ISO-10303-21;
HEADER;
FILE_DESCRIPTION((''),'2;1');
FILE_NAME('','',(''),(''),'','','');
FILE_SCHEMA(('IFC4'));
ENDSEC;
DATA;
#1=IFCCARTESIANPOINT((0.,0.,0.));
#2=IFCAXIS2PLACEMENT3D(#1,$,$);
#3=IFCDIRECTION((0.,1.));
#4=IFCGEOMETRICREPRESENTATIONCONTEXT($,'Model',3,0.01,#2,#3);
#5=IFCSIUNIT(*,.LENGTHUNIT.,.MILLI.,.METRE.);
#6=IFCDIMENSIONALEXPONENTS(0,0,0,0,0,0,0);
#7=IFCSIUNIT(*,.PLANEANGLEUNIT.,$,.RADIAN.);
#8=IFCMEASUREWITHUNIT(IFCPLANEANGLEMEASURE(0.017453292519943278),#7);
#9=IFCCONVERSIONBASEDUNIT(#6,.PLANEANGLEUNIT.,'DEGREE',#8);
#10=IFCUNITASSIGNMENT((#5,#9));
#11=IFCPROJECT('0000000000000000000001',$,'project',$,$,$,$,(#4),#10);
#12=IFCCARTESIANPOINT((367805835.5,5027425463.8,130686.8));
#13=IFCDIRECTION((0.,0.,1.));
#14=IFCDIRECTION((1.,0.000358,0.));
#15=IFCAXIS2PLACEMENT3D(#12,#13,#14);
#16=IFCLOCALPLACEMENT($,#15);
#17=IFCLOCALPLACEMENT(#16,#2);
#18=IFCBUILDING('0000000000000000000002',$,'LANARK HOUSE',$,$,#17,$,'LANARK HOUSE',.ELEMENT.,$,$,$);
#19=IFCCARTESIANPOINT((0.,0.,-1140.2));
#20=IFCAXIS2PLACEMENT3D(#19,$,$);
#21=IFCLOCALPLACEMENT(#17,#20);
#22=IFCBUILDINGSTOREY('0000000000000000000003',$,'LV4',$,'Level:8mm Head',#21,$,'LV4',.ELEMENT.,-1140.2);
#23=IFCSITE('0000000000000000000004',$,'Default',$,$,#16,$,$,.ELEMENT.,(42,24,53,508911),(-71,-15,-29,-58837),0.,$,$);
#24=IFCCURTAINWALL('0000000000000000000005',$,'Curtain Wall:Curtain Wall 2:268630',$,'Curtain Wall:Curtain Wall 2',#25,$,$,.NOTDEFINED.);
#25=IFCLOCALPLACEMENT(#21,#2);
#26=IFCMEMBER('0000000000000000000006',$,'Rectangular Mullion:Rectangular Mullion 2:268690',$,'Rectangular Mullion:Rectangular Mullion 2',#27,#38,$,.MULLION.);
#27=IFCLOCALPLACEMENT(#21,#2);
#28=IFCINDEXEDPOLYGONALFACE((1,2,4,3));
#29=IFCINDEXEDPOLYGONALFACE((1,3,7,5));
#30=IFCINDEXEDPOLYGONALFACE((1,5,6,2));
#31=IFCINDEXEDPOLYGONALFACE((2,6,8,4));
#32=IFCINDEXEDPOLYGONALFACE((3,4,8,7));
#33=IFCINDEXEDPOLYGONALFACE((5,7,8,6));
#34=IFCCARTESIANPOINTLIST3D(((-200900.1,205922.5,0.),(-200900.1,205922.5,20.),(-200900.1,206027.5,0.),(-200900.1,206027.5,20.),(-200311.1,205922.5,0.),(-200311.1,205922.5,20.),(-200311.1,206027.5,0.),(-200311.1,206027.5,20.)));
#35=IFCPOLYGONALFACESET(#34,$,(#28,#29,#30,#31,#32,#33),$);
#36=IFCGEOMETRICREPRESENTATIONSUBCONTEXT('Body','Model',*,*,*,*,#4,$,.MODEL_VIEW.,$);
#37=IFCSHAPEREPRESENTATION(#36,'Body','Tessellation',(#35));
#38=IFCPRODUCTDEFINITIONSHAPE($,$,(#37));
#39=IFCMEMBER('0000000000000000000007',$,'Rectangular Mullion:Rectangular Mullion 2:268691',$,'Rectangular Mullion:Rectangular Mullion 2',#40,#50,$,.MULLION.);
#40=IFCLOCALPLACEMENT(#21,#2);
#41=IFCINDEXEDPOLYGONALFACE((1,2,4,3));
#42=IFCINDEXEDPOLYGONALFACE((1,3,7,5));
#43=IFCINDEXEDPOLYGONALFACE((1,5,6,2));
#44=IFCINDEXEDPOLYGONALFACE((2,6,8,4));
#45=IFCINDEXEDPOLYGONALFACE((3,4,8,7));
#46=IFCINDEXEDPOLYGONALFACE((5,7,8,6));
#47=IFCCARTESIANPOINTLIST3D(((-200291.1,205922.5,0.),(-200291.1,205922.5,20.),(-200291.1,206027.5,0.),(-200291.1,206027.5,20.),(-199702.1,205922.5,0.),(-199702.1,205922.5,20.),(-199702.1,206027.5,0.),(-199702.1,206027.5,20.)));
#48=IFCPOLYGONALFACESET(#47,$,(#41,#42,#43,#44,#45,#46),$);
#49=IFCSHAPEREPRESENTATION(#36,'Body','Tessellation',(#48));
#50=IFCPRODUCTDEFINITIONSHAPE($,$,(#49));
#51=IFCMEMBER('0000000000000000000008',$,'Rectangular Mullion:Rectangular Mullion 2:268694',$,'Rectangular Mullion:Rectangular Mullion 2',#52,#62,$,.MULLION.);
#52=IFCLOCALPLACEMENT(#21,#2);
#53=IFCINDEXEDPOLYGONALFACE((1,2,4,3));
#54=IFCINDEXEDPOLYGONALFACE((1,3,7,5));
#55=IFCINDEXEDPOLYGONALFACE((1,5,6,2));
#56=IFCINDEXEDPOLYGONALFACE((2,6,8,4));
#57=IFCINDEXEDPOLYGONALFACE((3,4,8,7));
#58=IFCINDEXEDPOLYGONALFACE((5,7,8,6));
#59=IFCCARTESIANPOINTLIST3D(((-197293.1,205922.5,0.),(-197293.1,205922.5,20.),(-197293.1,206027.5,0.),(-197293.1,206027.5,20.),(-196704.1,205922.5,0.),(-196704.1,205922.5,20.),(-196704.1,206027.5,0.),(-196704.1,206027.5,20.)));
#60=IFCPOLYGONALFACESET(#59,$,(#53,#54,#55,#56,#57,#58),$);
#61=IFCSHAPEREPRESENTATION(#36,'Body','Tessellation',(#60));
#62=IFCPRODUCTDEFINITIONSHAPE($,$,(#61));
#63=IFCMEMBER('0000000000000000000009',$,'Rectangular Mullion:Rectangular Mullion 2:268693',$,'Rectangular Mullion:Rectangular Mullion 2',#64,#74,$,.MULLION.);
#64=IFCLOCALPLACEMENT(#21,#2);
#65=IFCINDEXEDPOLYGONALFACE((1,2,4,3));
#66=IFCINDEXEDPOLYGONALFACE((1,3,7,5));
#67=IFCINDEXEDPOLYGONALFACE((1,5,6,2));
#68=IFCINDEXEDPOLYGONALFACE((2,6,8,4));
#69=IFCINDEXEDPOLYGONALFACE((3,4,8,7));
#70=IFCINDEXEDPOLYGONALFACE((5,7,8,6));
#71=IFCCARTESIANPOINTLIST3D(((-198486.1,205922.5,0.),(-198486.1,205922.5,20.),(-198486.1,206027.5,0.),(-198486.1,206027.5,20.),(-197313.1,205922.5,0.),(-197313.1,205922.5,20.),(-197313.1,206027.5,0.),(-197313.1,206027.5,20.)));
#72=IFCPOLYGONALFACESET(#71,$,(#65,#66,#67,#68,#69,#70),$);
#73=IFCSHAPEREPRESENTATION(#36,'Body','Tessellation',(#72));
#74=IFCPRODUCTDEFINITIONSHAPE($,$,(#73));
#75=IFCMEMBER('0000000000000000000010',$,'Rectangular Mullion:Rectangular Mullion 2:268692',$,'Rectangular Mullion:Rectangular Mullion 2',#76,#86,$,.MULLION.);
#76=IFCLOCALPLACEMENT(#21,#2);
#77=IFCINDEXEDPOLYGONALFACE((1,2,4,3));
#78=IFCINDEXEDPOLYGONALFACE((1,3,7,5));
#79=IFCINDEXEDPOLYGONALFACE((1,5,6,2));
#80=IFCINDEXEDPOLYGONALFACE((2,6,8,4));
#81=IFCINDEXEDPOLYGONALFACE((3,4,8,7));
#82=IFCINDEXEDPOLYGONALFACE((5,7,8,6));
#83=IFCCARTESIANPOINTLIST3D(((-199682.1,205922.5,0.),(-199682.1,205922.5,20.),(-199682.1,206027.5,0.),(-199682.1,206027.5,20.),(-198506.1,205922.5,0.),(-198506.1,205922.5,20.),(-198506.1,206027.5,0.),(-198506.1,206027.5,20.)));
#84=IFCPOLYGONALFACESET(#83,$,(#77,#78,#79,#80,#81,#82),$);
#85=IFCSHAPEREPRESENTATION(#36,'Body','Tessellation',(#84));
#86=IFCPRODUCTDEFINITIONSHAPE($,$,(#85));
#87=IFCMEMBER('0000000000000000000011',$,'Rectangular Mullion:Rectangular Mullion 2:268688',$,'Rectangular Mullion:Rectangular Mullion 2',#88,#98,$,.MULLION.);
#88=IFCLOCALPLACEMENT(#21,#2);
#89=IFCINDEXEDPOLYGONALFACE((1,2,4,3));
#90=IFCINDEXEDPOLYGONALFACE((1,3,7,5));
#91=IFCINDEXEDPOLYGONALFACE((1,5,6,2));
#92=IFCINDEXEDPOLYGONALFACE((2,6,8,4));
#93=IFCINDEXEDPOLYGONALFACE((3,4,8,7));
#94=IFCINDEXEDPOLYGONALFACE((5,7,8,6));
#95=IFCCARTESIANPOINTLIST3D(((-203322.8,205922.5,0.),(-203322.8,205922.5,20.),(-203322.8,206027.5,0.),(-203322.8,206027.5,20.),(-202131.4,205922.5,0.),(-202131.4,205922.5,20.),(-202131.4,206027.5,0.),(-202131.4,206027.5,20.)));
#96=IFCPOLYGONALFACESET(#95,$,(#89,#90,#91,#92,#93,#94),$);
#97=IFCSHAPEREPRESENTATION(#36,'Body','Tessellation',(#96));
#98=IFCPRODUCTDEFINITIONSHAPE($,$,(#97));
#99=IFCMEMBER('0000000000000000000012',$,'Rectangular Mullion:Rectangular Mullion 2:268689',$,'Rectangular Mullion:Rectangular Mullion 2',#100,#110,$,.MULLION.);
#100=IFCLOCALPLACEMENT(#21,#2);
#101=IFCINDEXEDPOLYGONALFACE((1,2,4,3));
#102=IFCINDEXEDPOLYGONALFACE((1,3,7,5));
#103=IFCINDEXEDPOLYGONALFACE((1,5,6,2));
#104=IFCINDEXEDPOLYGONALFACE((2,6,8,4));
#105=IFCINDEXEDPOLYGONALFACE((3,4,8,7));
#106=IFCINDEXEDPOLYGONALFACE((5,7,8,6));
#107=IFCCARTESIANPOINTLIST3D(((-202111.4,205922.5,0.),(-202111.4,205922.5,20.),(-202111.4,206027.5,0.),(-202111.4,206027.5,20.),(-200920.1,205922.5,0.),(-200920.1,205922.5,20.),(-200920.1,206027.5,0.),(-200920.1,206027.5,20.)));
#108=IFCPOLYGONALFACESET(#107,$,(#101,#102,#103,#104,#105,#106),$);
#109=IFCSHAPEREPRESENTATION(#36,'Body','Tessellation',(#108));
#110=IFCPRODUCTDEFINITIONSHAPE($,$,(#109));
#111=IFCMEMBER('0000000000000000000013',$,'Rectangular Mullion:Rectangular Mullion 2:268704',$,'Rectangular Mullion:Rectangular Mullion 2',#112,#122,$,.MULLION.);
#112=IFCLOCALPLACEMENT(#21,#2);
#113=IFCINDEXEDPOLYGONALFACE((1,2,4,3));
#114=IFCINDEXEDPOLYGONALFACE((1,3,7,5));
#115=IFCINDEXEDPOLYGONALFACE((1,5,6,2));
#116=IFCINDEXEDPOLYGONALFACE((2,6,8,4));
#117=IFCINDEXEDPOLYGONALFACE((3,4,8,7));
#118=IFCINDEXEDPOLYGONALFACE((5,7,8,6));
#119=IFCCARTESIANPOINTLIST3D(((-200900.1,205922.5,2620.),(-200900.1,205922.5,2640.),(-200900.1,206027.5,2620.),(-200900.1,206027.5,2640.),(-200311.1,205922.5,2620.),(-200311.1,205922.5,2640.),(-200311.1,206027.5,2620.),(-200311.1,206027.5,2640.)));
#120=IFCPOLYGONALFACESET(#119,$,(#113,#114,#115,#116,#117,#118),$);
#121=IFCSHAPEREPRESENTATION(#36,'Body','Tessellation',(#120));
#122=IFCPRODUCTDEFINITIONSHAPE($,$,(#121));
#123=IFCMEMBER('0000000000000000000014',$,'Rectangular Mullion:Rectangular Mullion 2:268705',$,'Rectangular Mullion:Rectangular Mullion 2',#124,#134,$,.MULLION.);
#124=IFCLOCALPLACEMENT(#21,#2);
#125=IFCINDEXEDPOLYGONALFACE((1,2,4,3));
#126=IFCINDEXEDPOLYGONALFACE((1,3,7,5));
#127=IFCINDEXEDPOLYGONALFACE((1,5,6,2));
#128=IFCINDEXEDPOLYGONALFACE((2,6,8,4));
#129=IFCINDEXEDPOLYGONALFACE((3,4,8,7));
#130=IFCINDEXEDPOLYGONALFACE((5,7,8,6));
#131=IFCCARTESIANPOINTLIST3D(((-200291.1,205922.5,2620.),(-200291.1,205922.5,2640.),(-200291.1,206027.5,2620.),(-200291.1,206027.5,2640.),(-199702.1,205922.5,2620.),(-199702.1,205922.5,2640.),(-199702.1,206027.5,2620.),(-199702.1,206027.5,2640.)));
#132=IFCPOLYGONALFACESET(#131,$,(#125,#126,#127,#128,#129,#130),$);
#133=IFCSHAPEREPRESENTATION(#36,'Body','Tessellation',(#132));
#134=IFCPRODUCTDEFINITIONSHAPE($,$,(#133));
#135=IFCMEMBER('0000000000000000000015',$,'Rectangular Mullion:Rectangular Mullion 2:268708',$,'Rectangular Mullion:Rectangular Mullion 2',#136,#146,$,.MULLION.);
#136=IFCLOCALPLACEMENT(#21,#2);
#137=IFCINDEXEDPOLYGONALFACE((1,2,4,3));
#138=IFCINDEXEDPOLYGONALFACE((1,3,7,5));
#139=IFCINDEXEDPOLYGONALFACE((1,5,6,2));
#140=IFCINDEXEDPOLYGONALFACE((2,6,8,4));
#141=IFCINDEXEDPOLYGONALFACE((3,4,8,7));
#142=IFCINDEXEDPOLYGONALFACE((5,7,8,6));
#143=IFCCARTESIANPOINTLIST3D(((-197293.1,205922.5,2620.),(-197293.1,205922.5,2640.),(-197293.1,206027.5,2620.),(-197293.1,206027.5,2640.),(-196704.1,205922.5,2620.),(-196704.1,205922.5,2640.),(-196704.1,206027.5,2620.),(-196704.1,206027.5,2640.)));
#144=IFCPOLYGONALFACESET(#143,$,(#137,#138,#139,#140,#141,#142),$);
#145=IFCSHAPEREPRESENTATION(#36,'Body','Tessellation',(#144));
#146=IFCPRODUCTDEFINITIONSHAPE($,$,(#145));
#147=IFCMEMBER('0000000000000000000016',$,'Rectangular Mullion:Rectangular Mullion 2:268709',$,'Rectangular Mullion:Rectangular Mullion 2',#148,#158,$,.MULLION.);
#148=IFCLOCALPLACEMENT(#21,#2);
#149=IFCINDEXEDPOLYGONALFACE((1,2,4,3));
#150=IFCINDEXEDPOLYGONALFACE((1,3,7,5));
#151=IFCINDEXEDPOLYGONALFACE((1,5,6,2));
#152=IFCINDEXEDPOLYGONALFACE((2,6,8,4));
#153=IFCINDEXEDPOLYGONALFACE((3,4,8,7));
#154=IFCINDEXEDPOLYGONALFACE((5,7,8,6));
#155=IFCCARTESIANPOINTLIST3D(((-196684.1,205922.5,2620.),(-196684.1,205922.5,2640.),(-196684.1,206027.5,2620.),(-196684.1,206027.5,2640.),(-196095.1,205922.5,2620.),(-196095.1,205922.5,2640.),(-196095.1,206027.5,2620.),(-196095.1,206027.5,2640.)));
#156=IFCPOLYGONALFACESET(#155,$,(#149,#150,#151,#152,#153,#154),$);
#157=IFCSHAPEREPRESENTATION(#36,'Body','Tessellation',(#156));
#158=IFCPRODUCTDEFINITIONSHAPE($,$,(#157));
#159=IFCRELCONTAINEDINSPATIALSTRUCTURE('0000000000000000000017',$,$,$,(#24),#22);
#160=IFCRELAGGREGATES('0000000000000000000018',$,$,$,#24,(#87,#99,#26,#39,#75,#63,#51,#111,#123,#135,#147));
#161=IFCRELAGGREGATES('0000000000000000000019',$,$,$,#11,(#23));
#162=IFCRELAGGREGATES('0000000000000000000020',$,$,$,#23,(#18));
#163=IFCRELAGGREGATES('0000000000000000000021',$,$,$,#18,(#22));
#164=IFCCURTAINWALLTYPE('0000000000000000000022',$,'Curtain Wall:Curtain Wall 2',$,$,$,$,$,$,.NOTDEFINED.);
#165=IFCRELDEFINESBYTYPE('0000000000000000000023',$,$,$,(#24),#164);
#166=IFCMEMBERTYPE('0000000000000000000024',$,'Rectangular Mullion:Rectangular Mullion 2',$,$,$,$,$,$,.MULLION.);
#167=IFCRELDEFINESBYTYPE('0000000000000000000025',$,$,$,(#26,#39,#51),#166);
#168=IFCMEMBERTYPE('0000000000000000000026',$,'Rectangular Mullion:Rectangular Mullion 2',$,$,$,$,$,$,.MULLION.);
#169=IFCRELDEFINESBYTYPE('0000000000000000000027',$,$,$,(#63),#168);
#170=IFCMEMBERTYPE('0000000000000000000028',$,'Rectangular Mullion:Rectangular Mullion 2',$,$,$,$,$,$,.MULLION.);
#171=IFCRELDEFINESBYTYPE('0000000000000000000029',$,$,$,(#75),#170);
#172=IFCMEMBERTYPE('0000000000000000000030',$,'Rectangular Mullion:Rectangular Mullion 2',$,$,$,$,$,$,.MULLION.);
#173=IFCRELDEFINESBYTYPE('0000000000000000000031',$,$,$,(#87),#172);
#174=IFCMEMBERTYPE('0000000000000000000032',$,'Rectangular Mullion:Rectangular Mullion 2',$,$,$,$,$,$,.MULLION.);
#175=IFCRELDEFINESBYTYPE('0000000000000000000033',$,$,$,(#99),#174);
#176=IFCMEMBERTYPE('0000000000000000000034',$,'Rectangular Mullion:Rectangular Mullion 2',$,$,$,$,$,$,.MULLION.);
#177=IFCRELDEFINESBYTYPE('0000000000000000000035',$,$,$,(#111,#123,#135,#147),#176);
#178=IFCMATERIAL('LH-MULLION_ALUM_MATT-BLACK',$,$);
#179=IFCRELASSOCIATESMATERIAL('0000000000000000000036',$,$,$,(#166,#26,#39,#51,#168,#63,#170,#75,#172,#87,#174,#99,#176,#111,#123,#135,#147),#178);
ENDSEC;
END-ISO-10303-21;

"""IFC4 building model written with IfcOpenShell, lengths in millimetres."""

from ifc_helpers import new_model, entity, si_unit, converted_unit, direction, frame, origin, place, context, subcontext, project, spatial, indexed_curve, outline, extrude, source, transform, mapped, material, type_object, type_shapes, element, aggregate, save


model = new_model("IFC4")

# Units and contexts
model_context = context("Model", 3, precision=0.01, world=origin(), true_north=direction((0.0, 1.0)))
body_context = subcontext(model_context, "Body", "Model", "MODEL_VIEW")
ifc_project = project(units=[si_unit("LENGTHUNIT", "METRE", prefix="MILLI"), converted_unit("PLANEANGLEUNIT", "DEGREE", entity("IfcPlaneAngleMeasure", 0.017453292519943278), si_unit("PLANEANGLEUNIT", "RADIAN"), dimensions=[0, 0, 0, 0, 0, 0, 0])], contexts=[model_context])

# Site, building, storey
site_placement = place(None, frame((367805835.5, 5027425463.8, 130686.8), z_axis=(0.0, 0.0, 1.0), x_axis=(1.0, 0.000358, 0.0)))
site = spatial("IfcSite", under=ifc_project, at=site_placement, Name="Default", CompositionType="ELEMENT", RefLatitude=(42, 24, 53, 508911), RefLongitude=(-71, -15, -29, -58837), RefElevation=0.0)
building_placement = place(site_placement, origin())
building = spatial("IfcBuilding", under=site, at=building_placement, Name="LANARK HOUSE", LongName="LANARK HOUSE", CompositionType="ELEMENT")
storey_placement = place(building_placement, frame((0.0, 0.0, -1140.2)))
storey = spatial("IfcBuildingStorey", under=building, at=storey_placement, Name="LV4", ObjectType="Level:8mm Head", LongName="LV4", CompositionType="ELEMENT", Elevation=-1140.2)

# Curtain wall, members
curtain_wall_type = type_object("IfcCurtainWallType", Name="Curtain Wall:Curtain Wall 2", PredefinedType="NOTDEFINED")
curtain_wall_placement = place(storey_placement, frame((0.0, 0.0, 1140.2)))
curtain_wall = element("IfcCurtainWall", 1, at=curtain_wall_placement, inside=storey, type_object=curtain_wall_type, Name="Curtain Wall:Curtain Wall 2:268630", ObjectType="Curtain Wall:Curtain Wall 2", PredefinedType="NOTDEFINED")
ifc_material_1 = material(Name="LH-MULLION_ALUM_MATT-BLACK")
member_type_1 = type_object("IfcMemberType", Name="Rectangular Mullion:Rectangular Mullion 2", PredefinedType="MULLION", material=ifc_material_1)
shared_shape_1 = source(origin(), body_context, "Body", "SweptSolid", [
    extrude(outline(indexed_curve([(-10.0, -52.5), (10.0, -52.5), (10.0, 52.5), (-10.0, 52.5), (-10.0, -52.5)], self_intersect=False)), frame((-10.0, -40.0, -589.0), z_axis=(0.0, 0.0, 1.0), x_axis=(-1.0, 0.0, 0.0)), (0.0, 0.0, 1.0), 589.0),
])
type_shapes(member_type_1, [shared_shape_1])
member_1_placement = place(curtain_wall_placement, frame((-200311.1, 206015.0, -1140.2), z_axis=(1.0, 0.0, 0.0), x_axis=(0.0, 0.0, -1.0)))
member_1 = element("IfcMember", 2, at=member_1_placement, type_object=member_type_1, material=ifc_material_1, Name="Rectangular Mullion:Rectangular Mullion 2:268690", ObjectType="Rectangular Mullion:Rectangular Mullion 2", PredefinedType="MULLION", context=body_context, shape_type="MappedRepresentation", body=[
    mapped(shared_shape_1, transform((0.0, 0.0, 0.0), scale=1.0)),
])
member_2_placement = place(curtain_wall_placement, frame((-199702.1, 206015.0, -1140.2), z_axis=(1.0, 0.0, 0.0), x_axis=(0.0, 0.0, -1.0)))
member_2 = element("IfcMember", 3, at=member_2_placement, type_object=member_type_1, material=ifc_material_1, Name="Rectangular Mullion:Rectangular Mullion 2:268691", ObjectType="Rectangular Mullion:Rectangular Mullion 2", PredefinedType="MULLION", context=body_context, shape_type="MappedRepresentation", body=[
    mapped(shared_shape_1, transform((0.0, 0.0, 0.0), scale=1.0)),
])
member_3_placement = place(curtain_wall_placement, frame((-196704.1, 206015.0, -1140.2), z_axis=(1.0, 0.0, 0.0), x_axis=(0.0, 0.0, -1.0)))
member_3 = element("IfcMember", 4, at=member_3_placement, type_object=member_type_1, material=ifc_material_1, Name="Rectangular Mullion:Rectangular Mullion 2:268694", ObjectType="Rectangular Mullion:Rectangular Mullion 2", PredefinedType="MULLION", context=body_context, shape_type="MappedRepresentation", body=[
    mapped(shared_shape_1, transform((0.0, 0.0, 0.0), scale=1.0)),
])
member_type_2 = type_object("IfcMemberType", Name="Rectangular Mullion:Rectangular Mullion 2", PredefinedType="MULLION", material=ifc_material_1)
shared_shape_2 = source(origin(), body_context, "Body", "SweptSolid", [
    extrude(outline(indexed_curve([(-10.0, -52.5), (10.0, -52.5), (10.0, 52.5), (-10.0, 52.5), (-10.0, -52.5)], self_intersect=False)), frame((-10.0, -40.0, -1173.0), z_axis=(0.0, 0.0, 1.0), x_axis=(-1.0, 0.0, 0.0)), (0.0, 0.0, 1.0), 1173.0),
])
type_shapes(member_type_2, [shared_shape_2])
member_4_placement = place(curtain_wall_placement, frame((-197313.1, 206015.0, -1140.2), z_axis=(1.0, 0.0, 0.0), x_axis=(0.0, 0.0, -1.0)))
member_4 = element("IfcMember", 5, at=member_4_placement, type_object=member_type_2, material=ifc_material_1, Name="Rectangular Mullion:Rectangular Mullion 2:268693", ObjectType="Rectangular Mullion:Rectangular Mullion 2", PredefinedType="MULLION", context=body_context, shape_type="MappedRepresentation", body=[
    mapped(shared_shape_2, transform((0.0, 0.0, 0.0), scale=1.0)),
])
member_type_3 = type_object("IfcMemberType", Name="Rectangular Mullion:Rectangular Mullion 2", PredefinedType="MULLION", material=ifc_material_1)
shared_shape_3 = source(origin(), body_context, "Body", "SweptSolid", [
    extrude(outline(indexed_curve([(-10.0, -52.5), (10.0, -52.5), (10.0, 52.5), (-10.0, 52.5), (-10.0, -52.5)], self_intersect=False)), frame((-10.0, -40.0, -1176.0), z_axis=(0.0, 0.0, 1.0), x_axis=(-1.0, 0.0, 0.0)), (0.0, 0.0, 1.0), 1176.0),
])
type_shapes(member_type_3, [shared_shape_3])
member_5_placement = place(curtain_wall_placement, frame((-198506.1, 206015.0, -1140.2), z_axis=(1.0, 0.0, 0.0), x_axis=(0.0, 0.0, -1.0)))
member_5 = element("IfcMember", 6, at=member_5_placement, type_object=member_type_3, material=ifc_material_1, Name="Rectangular Mullion:Rectangular Mullion 2:268692", ObjectType="Rectangular Mullion:Rectangular Mullion 2", PredefinedType="MULLION", context=body_context, shape_type="MappedRepresentation", body=[
    mapped(shared_shape_3, transform((0.0, 0.0, 0.0), scale=1.0)),
])
member_type_4 = type_object("IfcMemberType", Name="Rectangular Mullion:Rectangular Mullion 2", PredefinedType="MULLION", material=ifc_material_1)
shared_shape_4 = source(origin(), body_context, "Body", "SweptSolid", [
    extrude(outline(indexed_curve([(-10.0, -52.5), (10.0, -52.5), (10.0, 52.5), (-10.0, 52.5), (-10.0, -52.5)], self_intersect=False)), frame((-10.0, -40.0, -1191.5), z_axis=(0.0, 0.0, 1.0), x_axis=(-1.0, 0.0, 0.0)), (0.0, 0.0, 1.0), 1191.5),
])
type_shapes(member_type_4, [shared_shape_4])
member_6_placement = place(curtain_wall_placement, frame((-202131.4, 206015.0, -1140.2), z_axis=(1.0, 0.0, 0.0), x_axis=(0.0, 0.0, -1.0)))
member_6 = element("IfcMember", 7, at=member_6_placement, type_object=member_type_4, material=ifc_material_1, Name="Rectangular Mullion:Rectangular Mullion 2:268688", ObjectType="Rectangular Mullion:Rectangular Mullion 2", PredefinedType="MULLION", context=body_context, shape_type="MappedRepresentation", body=[
    mapped(shared_shape_4, transform((0.0, 0.0, 0.0), scale=1.0)),
])
member_type_5 = type_object("IfcMemberType", Name="Rectangular Mullion:Rectangular Mullion 2", PredefinedType="MULLION", material=ifc_material_1)
shared_shape_5 = source(origin(), body_context, "Body", "SweptSolid", [
    extrude(outline(indexed_curve([(-10.0, -52.5), (10.0, -52.5), (10.0, 52.5), (-10.0, 52.5), (-10.0, -52.5)], self_intersect=False)), frame((-10.0, -40.0, -1191.3), z_axis=(0.0, 0.0, 1.0), x_axis=(-1.0, 0.0, 0.0)), (0.0, 0.0, 1.0), 1191.3),
])
type_shapes(member_type_5, [shared_shape_5])
member_7_placement = place(curtain_wall_placement, frame((-200920.1, 206015.0, -1140.2), z_axis=(1.0, 0.0, 0.0), x_axis=(0.0, 0.0, -1.0)))
member_7 = element("IfcMember", 8, at=member_7_placement, type_object=member_type_5, material=ifc_material_1, Name="Rectangular Mullion:Rectangular Mullion 2:268689", ObjectType="Rectangular Mullion:Rectangular Mullion 2", PredefinedType="MULLION", context=body_context, shape_type="MappedRepresentation", body=[
    mapped(shared_shape_5, transform((0.0, 0.0, 0.0), scale=1.0)),
])
member_type_6 = type_object("IfcMemberType", Name="Rectangular Mullion:Rectangular Mullion 2", PredefinedType="MULLION", material=ifc_material_1)
shared_shape_6 = source(origin(), body_context, "Body", "SweptSolid", [
    extrude(outline(indexed_curve([(-10.0, -52.5), (10.0, -52.5), (10.0, 52.5), (-10.0, 52.5), (-10.0, -52.5)], self_intersect=False)), frame((-10.0, -40.0, -589.0), z_axis=(0.0, 0.0, 1.0), x_axis=(-1.0, 0.0, 0.0)), (0.0, 0.0, 1.0), 589.0),
])
type_shapes(member_type_6, [shared_shape_6])
member_8_placement = place(curtain_wall_placement, frame((-200900.1, 206015.0, 1499.8), z_axis=(-1.0, 0.0, 0.0), x_axis=(0.0, 0.0, 1.0)))
member_8 = element("IfcMember", 9, at=member_8_placement, type_object=member_type_6, material=ifc_material_1, Name="Rectangular Mullion:Rectangular Mullion 2:268704", ObjectType="Rectangular Mullion:Rectangular Mullion 2", PredefinedType="MULLION", context=body_context, shape_type="MappedRepresentation", body=[
    mapped(shared_shape_6, transform((0.0, 0.0, 0.0), scale=1.0)),
])
member_9_placement = place(curtain_wall_placement, frame((-200291.1, 206015.0, 1499.8), z_axis=(-1.0, 0.0, 0.0), x_axis=(0.0, 0.0, 1.0)))
member_9 = element("IfcMember", 10, at=member_9_placement, type_object=member_type_6, material=ifc_material_1, Name="Rectangular Mullion:Rectangular Mullion 2:268705", ObjectType="Rectangular Mullion:Rectangular Mullion 2", PredefinedType="MULLION", context=body_context, shape_type="MappedRepresentation", body=[
    mapped(shared_shape_6, transform((0.0, 0.0, 0.0), scale=1.0)),
])
member_10_placement = place(curtain_wall_placement, frame((-197293.1, 206015.0, 1499.8), z_axis=(-1.0, 0.0, 0.0), x_axis=(0.0, 0.0, 1.0)))
member_10 = element("IfcMember", 11, at=member_10_placement, type_object=member_type_6, material=ifc_material_1, Name="Rectangular Mullion:Rectangular Mullion 2:268708", ObjectType="Rectangular Mullion:Rectangular Mullion 2", PredefinedType="MULLION", context=body_context, shape_type="MappedRepresentation", body=[
    mapped(shared_shape_6, transform((0.0, 0.0, 0.0), scale=1.0)),
])
member_11_placement = place(curtain_wall_placement, frame((-196684.1, 206015.0, 1499.8), z_axis=(-1.0, 0.0, 0.0), x_axis=(0.0, 0.0, 1.0)))
member_11 = element("IfcMember", 12, at=member_11_placement, type_object=member_type_6, material=ifc_material_1, Name="Rectangular Mullion:Rectangular Mullion 2:268709", ObjectType="Rectangular Mullion:Rectangular Mullion 2", PredefinedType="MULLION", context=body_context, shape_type="MappedRepresentation", body=[
    mapped(shared_shape_6, transform((0.0, 0.0, 0.0), scale=1.0)),
])
aggregate(curtain_wall, [member_6, member_7, member_1, member_2, member_5, member_4, member_3, member_8, member_9, member_10, member_11])

save(model, "model.ifc")
